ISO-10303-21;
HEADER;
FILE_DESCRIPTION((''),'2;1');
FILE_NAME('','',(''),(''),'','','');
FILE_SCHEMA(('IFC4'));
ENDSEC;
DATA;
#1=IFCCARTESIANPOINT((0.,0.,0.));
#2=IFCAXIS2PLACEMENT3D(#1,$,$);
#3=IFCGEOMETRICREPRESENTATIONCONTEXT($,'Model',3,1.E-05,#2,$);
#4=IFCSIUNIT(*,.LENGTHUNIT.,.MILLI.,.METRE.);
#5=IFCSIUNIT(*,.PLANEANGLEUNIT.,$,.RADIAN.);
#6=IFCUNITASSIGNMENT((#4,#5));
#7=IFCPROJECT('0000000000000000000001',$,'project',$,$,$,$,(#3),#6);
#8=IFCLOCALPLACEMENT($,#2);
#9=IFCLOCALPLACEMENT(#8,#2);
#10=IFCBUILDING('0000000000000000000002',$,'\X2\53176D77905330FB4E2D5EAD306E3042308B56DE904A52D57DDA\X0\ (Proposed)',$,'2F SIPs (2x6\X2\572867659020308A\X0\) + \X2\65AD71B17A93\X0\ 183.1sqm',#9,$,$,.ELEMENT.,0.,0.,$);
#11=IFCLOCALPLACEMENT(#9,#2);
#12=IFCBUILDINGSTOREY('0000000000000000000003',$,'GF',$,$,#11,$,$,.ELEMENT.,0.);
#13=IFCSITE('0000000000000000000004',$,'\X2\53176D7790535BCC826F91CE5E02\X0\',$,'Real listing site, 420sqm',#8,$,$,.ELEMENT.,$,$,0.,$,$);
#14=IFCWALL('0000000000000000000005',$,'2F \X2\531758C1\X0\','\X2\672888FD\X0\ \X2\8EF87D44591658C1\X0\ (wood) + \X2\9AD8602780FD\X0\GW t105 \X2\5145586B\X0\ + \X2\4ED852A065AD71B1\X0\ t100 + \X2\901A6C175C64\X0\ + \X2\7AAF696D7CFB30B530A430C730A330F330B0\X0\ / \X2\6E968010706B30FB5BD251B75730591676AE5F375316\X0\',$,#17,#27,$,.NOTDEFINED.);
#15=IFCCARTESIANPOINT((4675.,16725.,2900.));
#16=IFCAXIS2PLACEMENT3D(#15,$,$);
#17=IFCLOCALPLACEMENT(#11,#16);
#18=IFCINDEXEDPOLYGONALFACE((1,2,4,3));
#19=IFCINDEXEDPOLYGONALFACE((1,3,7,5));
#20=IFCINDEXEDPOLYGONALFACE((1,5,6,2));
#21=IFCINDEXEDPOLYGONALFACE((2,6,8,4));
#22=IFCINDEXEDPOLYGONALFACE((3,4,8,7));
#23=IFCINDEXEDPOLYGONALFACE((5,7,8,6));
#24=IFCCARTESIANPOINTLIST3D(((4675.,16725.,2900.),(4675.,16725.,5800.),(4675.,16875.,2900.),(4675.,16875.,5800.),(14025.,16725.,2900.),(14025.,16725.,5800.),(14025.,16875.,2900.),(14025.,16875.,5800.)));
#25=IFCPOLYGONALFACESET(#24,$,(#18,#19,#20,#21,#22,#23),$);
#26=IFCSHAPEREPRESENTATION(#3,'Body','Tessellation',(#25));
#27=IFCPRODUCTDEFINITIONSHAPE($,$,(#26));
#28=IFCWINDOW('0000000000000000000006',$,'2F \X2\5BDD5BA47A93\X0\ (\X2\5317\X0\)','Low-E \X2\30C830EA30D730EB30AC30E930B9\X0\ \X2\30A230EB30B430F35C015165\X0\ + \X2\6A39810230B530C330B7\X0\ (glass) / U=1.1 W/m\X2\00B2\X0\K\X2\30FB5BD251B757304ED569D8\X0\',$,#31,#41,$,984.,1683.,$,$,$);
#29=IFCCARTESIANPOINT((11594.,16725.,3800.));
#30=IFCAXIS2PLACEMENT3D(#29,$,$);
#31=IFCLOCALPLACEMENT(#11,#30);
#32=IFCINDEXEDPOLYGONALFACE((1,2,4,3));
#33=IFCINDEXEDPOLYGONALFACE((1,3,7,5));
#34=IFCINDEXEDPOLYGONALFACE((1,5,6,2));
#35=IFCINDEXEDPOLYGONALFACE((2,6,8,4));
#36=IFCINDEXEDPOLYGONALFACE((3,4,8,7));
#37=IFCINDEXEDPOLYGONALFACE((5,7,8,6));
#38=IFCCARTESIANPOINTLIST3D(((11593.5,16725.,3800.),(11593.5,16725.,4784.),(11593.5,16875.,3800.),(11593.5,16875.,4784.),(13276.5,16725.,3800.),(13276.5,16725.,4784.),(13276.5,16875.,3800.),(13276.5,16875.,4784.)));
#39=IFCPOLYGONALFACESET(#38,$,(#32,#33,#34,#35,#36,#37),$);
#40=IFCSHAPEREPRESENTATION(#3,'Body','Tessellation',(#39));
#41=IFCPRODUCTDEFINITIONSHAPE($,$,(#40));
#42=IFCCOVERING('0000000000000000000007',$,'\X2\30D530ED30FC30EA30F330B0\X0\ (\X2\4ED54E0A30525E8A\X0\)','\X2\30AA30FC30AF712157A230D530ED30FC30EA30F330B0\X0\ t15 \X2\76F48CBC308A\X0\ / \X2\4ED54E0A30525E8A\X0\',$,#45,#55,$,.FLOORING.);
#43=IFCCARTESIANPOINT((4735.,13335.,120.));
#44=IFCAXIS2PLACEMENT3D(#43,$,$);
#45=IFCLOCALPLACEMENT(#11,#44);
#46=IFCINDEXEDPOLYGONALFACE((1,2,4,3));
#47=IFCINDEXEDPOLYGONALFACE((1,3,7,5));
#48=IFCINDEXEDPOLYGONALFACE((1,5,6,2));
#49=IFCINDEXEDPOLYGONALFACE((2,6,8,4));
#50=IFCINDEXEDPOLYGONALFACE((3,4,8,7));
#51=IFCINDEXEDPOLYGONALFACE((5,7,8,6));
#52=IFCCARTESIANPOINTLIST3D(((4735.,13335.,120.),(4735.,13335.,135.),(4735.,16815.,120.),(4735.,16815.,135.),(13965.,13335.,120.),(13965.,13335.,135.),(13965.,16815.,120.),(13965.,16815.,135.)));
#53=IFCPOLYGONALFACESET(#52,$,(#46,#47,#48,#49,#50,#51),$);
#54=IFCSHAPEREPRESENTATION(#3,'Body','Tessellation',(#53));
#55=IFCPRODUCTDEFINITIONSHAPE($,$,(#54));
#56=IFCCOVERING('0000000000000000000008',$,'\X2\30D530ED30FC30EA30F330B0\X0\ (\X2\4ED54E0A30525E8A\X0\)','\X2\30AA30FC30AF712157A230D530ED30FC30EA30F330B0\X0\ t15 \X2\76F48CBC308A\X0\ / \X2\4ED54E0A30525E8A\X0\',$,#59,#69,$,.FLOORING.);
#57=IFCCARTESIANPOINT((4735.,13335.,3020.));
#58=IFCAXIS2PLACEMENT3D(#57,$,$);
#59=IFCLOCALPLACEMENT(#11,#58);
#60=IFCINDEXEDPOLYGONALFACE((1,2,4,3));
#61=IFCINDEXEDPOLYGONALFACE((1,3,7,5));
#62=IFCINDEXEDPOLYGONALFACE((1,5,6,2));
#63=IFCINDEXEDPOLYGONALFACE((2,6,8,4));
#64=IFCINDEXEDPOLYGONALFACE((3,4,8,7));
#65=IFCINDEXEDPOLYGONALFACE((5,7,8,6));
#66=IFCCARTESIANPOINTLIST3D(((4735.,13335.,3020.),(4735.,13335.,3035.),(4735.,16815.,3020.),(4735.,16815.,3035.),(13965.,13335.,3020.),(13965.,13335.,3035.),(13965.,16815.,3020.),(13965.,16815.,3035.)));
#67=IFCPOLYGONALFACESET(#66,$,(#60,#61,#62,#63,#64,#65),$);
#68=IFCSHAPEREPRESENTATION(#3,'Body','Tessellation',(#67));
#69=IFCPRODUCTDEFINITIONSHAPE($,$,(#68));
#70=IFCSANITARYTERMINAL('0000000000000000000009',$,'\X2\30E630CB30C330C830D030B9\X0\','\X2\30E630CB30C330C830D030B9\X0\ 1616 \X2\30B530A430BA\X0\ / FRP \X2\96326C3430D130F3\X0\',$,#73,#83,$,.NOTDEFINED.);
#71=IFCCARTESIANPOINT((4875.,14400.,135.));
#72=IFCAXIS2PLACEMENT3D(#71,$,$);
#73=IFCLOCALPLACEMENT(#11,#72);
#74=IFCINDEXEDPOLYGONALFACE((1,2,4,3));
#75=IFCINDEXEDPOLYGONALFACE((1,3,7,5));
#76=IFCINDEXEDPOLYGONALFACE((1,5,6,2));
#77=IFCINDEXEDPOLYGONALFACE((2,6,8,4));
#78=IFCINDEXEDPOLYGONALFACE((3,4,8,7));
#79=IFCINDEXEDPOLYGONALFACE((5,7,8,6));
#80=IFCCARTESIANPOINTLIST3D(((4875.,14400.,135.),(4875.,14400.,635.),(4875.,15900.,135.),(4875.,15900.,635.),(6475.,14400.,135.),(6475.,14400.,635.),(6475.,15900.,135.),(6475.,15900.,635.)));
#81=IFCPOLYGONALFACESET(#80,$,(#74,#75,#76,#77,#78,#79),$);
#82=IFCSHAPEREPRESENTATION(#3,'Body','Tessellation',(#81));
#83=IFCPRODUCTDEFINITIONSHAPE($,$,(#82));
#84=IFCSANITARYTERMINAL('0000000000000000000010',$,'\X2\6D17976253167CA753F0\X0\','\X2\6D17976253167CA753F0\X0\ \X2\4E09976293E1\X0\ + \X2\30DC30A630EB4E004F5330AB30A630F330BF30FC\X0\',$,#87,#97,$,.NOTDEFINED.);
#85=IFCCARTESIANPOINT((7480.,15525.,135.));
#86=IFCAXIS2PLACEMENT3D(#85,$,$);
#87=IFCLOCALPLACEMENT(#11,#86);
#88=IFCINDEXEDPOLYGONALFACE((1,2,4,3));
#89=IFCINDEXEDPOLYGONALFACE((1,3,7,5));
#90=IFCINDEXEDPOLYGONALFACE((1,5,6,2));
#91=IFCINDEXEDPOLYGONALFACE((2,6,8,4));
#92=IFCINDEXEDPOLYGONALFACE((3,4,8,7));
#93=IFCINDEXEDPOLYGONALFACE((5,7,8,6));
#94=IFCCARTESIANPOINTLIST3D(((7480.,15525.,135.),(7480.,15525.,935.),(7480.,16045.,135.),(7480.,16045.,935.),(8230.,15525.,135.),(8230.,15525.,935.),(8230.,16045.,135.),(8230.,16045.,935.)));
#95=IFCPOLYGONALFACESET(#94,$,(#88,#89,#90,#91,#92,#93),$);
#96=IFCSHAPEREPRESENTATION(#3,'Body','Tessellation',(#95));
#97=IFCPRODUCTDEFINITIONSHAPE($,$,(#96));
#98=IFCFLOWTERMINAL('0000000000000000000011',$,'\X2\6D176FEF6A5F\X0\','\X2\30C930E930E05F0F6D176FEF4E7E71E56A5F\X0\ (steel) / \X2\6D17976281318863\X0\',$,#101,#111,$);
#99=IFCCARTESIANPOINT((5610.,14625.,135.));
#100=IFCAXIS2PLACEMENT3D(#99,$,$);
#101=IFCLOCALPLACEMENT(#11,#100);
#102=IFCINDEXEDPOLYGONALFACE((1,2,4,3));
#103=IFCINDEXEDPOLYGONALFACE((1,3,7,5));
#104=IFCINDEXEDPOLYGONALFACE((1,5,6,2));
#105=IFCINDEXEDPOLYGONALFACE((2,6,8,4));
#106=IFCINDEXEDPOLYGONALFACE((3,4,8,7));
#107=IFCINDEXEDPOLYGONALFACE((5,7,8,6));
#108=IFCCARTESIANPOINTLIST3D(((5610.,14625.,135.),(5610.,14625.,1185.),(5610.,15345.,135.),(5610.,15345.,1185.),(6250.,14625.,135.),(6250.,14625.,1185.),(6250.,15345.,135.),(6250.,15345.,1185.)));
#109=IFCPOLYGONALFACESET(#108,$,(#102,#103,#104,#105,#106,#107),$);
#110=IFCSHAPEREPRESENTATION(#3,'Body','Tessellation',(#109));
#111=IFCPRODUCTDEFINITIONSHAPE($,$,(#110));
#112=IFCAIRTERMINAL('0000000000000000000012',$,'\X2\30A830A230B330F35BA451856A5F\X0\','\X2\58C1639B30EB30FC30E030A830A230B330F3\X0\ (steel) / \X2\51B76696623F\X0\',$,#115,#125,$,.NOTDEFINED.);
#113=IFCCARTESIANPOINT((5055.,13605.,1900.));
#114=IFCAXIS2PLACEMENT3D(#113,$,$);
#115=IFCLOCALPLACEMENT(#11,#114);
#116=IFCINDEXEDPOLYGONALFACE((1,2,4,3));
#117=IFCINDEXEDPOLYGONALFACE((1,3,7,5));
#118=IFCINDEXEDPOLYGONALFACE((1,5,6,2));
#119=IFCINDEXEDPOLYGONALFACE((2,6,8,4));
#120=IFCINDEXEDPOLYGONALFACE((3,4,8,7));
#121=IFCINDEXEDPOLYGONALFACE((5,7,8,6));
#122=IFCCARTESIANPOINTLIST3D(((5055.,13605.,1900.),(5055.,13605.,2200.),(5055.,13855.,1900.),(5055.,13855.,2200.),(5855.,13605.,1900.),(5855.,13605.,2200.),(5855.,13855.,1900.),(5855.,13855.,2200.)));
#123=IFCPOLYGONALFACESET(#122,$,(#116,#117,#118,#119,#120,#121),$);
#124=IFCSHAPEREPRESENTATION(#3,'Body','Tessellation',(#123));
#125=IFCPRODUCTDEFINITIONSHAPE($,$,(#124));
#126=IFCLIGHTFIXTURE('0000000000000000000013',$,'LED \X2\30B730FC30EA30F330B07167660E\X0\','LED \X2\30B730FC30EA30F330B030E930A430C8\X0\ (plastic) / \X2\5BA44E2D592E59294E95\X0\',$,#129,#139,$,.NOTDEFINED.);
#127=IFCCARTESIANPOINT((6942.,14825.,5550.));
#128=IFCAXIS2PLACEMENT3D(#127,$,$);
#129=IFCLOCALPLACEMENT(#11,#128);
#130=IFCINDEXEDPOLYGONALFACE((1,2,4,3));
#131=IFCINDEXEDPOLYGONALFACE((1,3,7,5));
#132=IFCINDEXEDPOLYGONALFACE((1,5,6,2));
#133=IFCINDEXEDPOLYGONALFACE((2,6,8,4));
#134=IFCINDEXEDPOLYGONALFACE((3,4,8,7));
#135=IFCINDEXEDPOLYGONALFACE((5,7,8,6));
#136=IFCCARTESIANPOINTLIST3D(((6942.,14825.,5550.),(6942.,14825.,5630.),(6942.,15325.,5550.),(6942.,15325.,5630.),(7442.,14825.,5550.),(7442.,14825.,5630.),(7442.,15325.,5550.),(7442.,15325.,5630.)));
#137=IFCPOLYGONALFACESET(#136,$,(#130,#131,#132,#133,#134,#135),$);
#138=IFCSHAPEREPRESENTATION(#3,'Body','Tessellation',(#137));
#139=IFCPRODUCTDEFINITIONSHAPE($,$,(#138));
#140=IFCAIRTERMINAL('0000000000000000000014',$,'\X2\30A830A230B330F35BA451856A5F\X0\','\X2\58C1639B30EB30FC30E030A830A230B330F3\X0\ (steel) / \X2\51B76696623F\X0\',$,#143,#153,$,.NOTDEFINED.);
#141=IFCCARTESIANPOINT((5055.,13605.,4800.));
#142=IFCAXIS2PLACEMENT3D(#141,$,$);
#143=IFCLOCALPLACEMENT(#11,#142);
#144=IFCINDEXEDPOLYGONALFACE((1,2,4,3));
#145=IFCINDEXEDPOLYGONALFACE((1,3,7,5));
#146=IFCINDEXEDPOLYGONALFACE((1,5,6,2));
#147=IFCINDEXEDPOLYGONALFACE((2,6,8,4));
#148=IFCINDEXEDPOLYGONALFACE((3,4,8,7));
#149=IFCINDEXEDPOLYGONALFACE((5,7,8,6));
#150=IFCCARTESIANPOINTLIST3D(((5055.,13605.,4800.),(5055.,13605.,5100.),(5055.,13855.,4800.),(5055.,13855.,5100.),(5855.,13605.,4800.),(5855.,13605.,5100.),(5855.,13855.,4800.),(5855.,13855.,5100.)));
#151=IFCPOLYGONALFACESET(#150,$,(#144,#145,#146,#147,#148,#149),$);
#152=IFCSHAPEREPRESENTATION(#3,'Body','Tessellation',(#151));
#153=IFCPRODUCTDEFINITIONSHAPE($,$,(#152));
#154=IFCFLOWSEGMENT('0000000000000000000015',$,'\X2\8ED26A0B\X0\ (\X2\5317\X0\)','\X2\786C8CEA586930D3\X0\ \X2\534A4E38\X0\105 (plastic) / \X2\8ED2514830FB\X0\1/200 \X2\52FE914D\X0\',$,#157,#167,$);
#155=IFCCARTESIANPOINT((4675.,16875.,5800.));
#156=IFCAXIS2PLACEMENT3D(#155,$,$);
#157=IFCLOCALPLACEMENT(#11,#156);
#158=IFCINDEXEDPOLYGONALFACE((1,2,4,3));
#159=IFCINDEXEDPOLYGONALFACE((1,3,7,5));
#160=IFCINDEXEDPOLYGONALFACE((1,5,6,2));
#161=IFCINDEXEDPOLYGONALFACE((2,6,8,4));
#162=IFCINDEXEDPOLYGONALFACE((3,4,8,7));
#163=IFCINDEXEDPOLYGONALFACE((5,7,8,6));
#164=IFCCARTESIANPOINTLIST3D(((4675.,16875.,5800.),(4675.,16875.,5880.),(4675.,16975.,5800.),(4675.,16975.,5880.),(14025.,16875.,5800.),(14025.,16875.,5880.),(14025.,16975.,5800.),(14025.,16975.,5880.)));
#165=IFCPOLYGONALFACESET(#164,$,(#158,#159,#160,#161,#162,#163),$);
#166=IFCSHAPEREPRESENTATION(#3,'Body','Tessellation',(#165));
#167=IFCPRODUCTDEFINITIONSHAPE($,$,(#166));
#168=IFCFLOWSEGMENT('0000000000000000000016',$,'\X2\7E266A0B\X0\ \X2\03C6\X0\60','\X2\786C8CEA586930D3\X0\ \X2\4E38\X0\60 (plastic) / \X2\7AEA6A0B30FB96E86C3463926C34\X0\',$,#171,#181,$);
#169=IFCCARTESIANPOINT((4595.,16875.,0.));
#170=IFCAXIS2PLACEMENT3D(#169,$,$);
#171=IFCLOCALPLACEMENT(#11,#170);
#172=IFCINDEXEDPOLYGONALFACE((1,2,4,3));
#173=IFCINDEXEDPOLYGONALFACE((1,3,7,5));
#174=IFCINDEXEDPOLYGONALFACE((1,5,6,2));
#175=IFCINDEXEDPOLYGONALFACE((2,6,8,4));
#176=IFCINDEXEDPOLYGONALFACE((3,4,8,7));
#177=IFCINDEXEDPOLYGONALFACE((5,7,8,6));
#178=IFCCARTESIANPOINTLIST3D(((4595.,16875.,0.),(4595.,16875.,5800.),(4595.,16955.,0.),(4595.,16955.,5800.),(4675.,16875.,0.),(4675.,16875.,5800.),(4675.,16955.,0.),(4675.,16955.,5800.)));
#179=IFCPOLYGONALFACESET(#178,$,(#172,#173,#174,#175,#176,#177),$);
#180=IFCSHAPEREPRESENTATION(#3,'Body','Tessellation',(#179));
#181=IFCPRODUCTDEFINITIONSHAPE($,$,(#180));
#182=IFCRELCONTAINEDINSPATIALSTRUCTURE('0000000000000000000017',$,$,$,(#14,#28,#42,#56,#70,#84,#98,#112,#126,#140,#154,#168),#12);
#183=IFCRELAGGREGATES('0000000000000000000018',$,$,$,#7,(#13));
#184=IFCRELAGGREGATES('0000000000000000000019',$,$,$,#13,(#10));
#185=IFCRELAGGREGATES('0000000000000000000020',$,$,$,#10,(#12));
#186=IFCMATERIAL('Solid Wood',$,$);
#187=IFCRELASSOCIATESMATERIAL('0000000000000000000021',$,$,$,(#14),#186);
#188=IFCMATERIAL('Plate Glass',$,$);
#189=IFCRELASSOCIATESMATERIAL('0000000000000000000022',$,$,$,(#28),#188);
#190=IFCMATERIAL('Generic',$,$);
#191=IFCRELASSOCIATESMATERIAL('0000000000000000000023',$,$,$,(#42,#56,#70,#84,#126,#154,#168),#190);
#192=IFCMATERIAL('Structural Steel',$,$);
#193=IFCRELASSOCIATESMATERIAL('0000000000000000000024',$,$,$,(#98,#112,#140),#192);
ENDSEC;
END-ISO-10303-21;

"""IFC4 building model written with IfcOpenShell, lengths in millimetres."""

from ifc_helpers import new_model, si_unit, frame, frame_2d, origin, place, context, project, spatial, rectangle, extrude, material, element, fill, save


model = new_model("IFC4")

# Units and contexts
model_context = context("Model", 3, precision=1e-05, world=origin())
ifc_project = project(units=[si_unit("LENGTHUNIT", "METRE", prefix="MILLI"), si_unit("PLANEANGLEUNIT", "RADIAN")], contexts=[model_context])

# Site, building, storey
site_placement = place(None, origin())
site = spatial("IfcSite", under=ifc_project, at=site_placement, Name="北海道富良野市", ObjectType="Real listing site, 420sqm", CompositionType="ELEMENT", RefElevation=0.0)
building_placement = place(site_placement, origin())
building = spatial("IfcBuilding", under=site, at=building_placement, Name="北海道・中庭のある回遊動線 (Proposed)", ObjectType="2F SIPs (2x6在来造り) + 断熱窓 183.1sqm", CompositionType="ELEMENT", ElevationOfRefHeight=0.0, ElevationOfTerrain=0.0)
storey_placement = place(building_placement, origin())
storey = spatial("IfcBuildingStorey", under=building, at=storey_placement, Name="GF", CompositionType="ELEMENT", Elevation=0.0)

# Shared definitions
ifc_material_1 = material(Name="Solid Wood")

# Shared definitions
ifc_material_2 = material(Name="Plate Glass")

# Wall, opening, window
wall_1_placement = place(storey_placement, frame((4675.0, 16725.0, 2900.0)))
wall_1 = element("IfcWall", 1, at=wall_1_placement, inside=storey, material=ifc_material_1, Name="2F 北壁", Description="木製 軸組外壁 (wood) + 高性能GW t105 充填 + 付加断熱 t100 + 通気層 + 窯業系サイディング / 準耐火・寒冷地外皮強化", PredefinedType="NOTDEFINED", context=model_context, shape_type="SweptSolid", body=[
    extrude(rectangle(XDim=9350.0, YDim=150.0, at=frame_2d((4675.0, 75.0))), frame((4675.0, 16725.0, 2900.0)), (0.0, 0.0, 1.0), 2900.0),
])
opening_1_placement = place(storey_placement, frame((11594.0, 16725.0, 3800.0)))
opening_1 = element("IfcOpeningElement", 2, at=opening_1_placement, cuts=wall_1, PredefinedType="NOTDEFINED", context=model_context, shape_type="SweptSolid", body=[
    extrude(rectangle(XDim=1683.0, YDim=150.0, at=frame_2d((841.0, 75.0))), frame((11594.0, 16725.0, 3800.0)), (0.0, 0.0, 1.0), 984.0),
])
window_1_placement = place(storey_placement, frame((11594.0, 16725.0, 3800.0)))
window_1 = element("IfcWindow", 3, at=window_1_placement, inside=storey, material=ifc_material_2, Name="2F 寝室窓 (北)", Description="Low-E トリプルガラス アルゴン封入 + 樹脂サッシ (glass) / U=1.1 W/m²K・寒冷地仕様", OverallHeight=984.0, OverallWidth=1683.0, context=model_context, shape_type="SweptSolid", body=[
    extrude(rectangle(XDim=1683.0, YDim=150.0, at=frame_2d((841.0, 75.0))), frame((11594.0, 16725.0, 3800.0)), (0.0, 0.0, 1.0), 984.0),
])
fill(opening_1, window_1)

# Coverings
ifc_material_3 = material(Name="Generic")
covering_1_placement = place(storey_placement, frame((4735.0, 13335.0, 120.0)))
element("IfcCovering", 4, at=covering_1_placement, inside=storey, material=ifc_material_3, Name="フローリング (仕上げ床)", Description="オーク無垢フローリング t15 直貼り / 仕上げ床", PredefinedType="FLOORING", context=model_context, shape_type="SweptSolid", body=[
    extrude(rectangle(XDim=9230.0, YDim=3480.0, at=frame_2d((4615.0, 1740.0))), frame((4735.0, 13335.0, 120.0)), (0.0, 0.0, 1.0), 15.0),
])
covering_2_placement = place(storey_placement, frame((4735.0, 13335.0, 3020.0)))
element("IfcCovering", 5, at=covering_2_placement, inside=storey, material=ifc_material_3, Name="フローリング (仕上げ床)", Description="オーク無垢フローリング t15 直貼り / 仕上げ床", PredefinedType="FLOORING", context=model_context, shape_type="SweptSolid", body=[
    extrude(rectangle(XDim=9230.0, YDim=3480.0, at=frame_2d((4615.0, 1740.0))), frame((4735.0, 13335.0, 3020.0)), (0.0, 0.0, 1.0), 15.0),
])

# Sanitary terminals
sanitary_terminal_1_placement = place(storey_placement, frame((4875.0, 14400.0, 135.0)))
element("IfcSanitaryTerminal", 6, at=sanitary_terminal_1_placement, inside=storey, material=ifc_material_3, Name="ユニットバス", Description="ユニットバス 1616 サイズ / FRP 防水パン", PredefinedType="NOTDEFINED", context=model_context, shape_type="SweptSolid", body=[
    extrude(rectangle(XDim=1600.0, YDim=1500.0, at=frame_2d((800.0, 750.0))), frame((4875.0, 14400.0, 135.0)), (0.0, 0.0, 1.0), 500.0),
])
sanitary_terminal_2_placement = place(storey_placement, frame((7480.0, 15525.0, 135.0)))
element("IfcSanitaryTerminal", 7, at=sanitary_terminal_2_placement, inside=storey, material=ifc_material_3, Name="洗面化粧台", Description="洗面化粧台 三面鏡 + ボウル一体カウンター", PredefinedType="NOTDEFINED", context=model_context, shape_type="SweptSolid", body=[
    extrude(rectangle(XDim=750.0, YDim=520.0, at=frame_2d((375.0, 260.0))), frame((7480.0, 15525.0, 135.0)), (0.0, 0.0, 1.0), 800.0),
])

# Flow terminal
ifc_material_4 = material(Name="Structural Steel")
flow_terminal_placement = place(storey_placement, frame((5610.0, 14625.0, 135.0)))
element("IfcFlowTerminal", 8, at=flow_terminal_placement, inside=storey, material=ifc_material_4, Name="洗濯機", Description="ドラム式洗濯乾燥機 (steel) / 洗面脱衣", context=model_context, shape_type="SweptSolid", body=[
    extrude(rectangle(XDim=640.0, YDim=720.0, at=frame_2d((320.0, 360.0))), frame((5610.0, 14625.0, 135.0)), (0.0, 0.0, 1.0), 1050.0),
])

# Air terminal
air_terminal_1_placement = place(storey_placement, frame((5055.0, 13605.0, 1900.0)))
element("IfcAirTerminal", 9, at=air_terminal_1_placement, inside=storey, material=ifc_material_4, Name="エアコン室内機", Description="壁掛ルームエアコン (steel) / 冷暖房", PredefinedType="NOTDEFINED", context=model_context, shape_type="SweptSolid", body=[
    extrude(rectangle(XDim=800.0, YDim=250.0, at=frame_2d((400.0, 125.0))), frame((5055.0, 13605.0, 1900.0)), (0.0, 0.0, 1.0), 300.0),
])

# Light fixture
light_fixture_placement = place(storey_placement, frame((6942.0, 14825.0, 5550.0)))
element("IfcLightFixture", 10, at=light_fixture_placement, inside=storey, material=ifc_material_3, Name="LED シーリング照明", Description="LED シーリングライト (plastic) / 室中央天井", PredefinedType="NOTDEFINED", context=model_context, shape_type="SweptSolid", body=[
    extrude(rectangle(XDim=500.0, YDim=500.0, at=frame_2d((250.0, 250.0))), frame((6942.0, 14825.0, 5550.0)), (0.0, 0.0, 1.0), 80.0),
])

# Air terminal
air_terminal_2_placement = place(storey_placement, frame((5055.0, 13605.0, 4800.0)))
element("IfcAirTerminal", 11, at=air_terminal_2_placement, inside=storey, material=ifc_material_4, Name="エアコン室内機", Description="壁掛ルームエアコン (steel) / 冷暖房", PredefinedType="NOTDEFINED", context=model_context, shape_type="SweptSolid", body=[
    extrude(rectangle(XDim=800.0, YDim=250.0, at=frame_2d((400.0, 125.0))), frame((5055.0, 13605.0, 4800.0)), (0.0, 0.0, 1.0), 300.0),
])

# Flow segments
flow_segment_1_placement = place(storey_placement, frame((4675.0, 16875.0, 5800.0)))
element("IfcFlowSegment", 12, at=flow_segment_1_placement, inside=storey, material=ifc_material_3, Name="軒樋 (北)", Description="硬質塩ビ 半丸105 (plastic) / 軒先・1/200 勾配", context=model_context, shape_type="SweptSolid", body=[
    extrude(rectangle(XDim=9350.0, YDim=100.0, at=frame_2d((4675.0, 50.0))), frame((4675.0, 16875.0, 5800.0)), (0.0, 0.0, 1.0), 80.0),
])
flow_segment_2_placement = place(storey_placement, frame((4595.0, 16875.0, 0.0)))
element("IfcFlowSegment", 13, at=flow_segment_2_placement, inside=storey, material=ifc_material_3, Name="縦樋 φ60", Description="硬質塩ビ 丸60 (plastic) / 竪樋・雨水排水", context=model_context, shape_type="SweptSolid", body=[
    extrude(rectangle(XDim=80.0, YDim=80.0, at=frame_2d((40.0, 40.0))), frame((4595.0, 16875.0, 0.0)), (0.0, 0.0, 1.0), 5800.0),
])

save(model, "model.ifc")
